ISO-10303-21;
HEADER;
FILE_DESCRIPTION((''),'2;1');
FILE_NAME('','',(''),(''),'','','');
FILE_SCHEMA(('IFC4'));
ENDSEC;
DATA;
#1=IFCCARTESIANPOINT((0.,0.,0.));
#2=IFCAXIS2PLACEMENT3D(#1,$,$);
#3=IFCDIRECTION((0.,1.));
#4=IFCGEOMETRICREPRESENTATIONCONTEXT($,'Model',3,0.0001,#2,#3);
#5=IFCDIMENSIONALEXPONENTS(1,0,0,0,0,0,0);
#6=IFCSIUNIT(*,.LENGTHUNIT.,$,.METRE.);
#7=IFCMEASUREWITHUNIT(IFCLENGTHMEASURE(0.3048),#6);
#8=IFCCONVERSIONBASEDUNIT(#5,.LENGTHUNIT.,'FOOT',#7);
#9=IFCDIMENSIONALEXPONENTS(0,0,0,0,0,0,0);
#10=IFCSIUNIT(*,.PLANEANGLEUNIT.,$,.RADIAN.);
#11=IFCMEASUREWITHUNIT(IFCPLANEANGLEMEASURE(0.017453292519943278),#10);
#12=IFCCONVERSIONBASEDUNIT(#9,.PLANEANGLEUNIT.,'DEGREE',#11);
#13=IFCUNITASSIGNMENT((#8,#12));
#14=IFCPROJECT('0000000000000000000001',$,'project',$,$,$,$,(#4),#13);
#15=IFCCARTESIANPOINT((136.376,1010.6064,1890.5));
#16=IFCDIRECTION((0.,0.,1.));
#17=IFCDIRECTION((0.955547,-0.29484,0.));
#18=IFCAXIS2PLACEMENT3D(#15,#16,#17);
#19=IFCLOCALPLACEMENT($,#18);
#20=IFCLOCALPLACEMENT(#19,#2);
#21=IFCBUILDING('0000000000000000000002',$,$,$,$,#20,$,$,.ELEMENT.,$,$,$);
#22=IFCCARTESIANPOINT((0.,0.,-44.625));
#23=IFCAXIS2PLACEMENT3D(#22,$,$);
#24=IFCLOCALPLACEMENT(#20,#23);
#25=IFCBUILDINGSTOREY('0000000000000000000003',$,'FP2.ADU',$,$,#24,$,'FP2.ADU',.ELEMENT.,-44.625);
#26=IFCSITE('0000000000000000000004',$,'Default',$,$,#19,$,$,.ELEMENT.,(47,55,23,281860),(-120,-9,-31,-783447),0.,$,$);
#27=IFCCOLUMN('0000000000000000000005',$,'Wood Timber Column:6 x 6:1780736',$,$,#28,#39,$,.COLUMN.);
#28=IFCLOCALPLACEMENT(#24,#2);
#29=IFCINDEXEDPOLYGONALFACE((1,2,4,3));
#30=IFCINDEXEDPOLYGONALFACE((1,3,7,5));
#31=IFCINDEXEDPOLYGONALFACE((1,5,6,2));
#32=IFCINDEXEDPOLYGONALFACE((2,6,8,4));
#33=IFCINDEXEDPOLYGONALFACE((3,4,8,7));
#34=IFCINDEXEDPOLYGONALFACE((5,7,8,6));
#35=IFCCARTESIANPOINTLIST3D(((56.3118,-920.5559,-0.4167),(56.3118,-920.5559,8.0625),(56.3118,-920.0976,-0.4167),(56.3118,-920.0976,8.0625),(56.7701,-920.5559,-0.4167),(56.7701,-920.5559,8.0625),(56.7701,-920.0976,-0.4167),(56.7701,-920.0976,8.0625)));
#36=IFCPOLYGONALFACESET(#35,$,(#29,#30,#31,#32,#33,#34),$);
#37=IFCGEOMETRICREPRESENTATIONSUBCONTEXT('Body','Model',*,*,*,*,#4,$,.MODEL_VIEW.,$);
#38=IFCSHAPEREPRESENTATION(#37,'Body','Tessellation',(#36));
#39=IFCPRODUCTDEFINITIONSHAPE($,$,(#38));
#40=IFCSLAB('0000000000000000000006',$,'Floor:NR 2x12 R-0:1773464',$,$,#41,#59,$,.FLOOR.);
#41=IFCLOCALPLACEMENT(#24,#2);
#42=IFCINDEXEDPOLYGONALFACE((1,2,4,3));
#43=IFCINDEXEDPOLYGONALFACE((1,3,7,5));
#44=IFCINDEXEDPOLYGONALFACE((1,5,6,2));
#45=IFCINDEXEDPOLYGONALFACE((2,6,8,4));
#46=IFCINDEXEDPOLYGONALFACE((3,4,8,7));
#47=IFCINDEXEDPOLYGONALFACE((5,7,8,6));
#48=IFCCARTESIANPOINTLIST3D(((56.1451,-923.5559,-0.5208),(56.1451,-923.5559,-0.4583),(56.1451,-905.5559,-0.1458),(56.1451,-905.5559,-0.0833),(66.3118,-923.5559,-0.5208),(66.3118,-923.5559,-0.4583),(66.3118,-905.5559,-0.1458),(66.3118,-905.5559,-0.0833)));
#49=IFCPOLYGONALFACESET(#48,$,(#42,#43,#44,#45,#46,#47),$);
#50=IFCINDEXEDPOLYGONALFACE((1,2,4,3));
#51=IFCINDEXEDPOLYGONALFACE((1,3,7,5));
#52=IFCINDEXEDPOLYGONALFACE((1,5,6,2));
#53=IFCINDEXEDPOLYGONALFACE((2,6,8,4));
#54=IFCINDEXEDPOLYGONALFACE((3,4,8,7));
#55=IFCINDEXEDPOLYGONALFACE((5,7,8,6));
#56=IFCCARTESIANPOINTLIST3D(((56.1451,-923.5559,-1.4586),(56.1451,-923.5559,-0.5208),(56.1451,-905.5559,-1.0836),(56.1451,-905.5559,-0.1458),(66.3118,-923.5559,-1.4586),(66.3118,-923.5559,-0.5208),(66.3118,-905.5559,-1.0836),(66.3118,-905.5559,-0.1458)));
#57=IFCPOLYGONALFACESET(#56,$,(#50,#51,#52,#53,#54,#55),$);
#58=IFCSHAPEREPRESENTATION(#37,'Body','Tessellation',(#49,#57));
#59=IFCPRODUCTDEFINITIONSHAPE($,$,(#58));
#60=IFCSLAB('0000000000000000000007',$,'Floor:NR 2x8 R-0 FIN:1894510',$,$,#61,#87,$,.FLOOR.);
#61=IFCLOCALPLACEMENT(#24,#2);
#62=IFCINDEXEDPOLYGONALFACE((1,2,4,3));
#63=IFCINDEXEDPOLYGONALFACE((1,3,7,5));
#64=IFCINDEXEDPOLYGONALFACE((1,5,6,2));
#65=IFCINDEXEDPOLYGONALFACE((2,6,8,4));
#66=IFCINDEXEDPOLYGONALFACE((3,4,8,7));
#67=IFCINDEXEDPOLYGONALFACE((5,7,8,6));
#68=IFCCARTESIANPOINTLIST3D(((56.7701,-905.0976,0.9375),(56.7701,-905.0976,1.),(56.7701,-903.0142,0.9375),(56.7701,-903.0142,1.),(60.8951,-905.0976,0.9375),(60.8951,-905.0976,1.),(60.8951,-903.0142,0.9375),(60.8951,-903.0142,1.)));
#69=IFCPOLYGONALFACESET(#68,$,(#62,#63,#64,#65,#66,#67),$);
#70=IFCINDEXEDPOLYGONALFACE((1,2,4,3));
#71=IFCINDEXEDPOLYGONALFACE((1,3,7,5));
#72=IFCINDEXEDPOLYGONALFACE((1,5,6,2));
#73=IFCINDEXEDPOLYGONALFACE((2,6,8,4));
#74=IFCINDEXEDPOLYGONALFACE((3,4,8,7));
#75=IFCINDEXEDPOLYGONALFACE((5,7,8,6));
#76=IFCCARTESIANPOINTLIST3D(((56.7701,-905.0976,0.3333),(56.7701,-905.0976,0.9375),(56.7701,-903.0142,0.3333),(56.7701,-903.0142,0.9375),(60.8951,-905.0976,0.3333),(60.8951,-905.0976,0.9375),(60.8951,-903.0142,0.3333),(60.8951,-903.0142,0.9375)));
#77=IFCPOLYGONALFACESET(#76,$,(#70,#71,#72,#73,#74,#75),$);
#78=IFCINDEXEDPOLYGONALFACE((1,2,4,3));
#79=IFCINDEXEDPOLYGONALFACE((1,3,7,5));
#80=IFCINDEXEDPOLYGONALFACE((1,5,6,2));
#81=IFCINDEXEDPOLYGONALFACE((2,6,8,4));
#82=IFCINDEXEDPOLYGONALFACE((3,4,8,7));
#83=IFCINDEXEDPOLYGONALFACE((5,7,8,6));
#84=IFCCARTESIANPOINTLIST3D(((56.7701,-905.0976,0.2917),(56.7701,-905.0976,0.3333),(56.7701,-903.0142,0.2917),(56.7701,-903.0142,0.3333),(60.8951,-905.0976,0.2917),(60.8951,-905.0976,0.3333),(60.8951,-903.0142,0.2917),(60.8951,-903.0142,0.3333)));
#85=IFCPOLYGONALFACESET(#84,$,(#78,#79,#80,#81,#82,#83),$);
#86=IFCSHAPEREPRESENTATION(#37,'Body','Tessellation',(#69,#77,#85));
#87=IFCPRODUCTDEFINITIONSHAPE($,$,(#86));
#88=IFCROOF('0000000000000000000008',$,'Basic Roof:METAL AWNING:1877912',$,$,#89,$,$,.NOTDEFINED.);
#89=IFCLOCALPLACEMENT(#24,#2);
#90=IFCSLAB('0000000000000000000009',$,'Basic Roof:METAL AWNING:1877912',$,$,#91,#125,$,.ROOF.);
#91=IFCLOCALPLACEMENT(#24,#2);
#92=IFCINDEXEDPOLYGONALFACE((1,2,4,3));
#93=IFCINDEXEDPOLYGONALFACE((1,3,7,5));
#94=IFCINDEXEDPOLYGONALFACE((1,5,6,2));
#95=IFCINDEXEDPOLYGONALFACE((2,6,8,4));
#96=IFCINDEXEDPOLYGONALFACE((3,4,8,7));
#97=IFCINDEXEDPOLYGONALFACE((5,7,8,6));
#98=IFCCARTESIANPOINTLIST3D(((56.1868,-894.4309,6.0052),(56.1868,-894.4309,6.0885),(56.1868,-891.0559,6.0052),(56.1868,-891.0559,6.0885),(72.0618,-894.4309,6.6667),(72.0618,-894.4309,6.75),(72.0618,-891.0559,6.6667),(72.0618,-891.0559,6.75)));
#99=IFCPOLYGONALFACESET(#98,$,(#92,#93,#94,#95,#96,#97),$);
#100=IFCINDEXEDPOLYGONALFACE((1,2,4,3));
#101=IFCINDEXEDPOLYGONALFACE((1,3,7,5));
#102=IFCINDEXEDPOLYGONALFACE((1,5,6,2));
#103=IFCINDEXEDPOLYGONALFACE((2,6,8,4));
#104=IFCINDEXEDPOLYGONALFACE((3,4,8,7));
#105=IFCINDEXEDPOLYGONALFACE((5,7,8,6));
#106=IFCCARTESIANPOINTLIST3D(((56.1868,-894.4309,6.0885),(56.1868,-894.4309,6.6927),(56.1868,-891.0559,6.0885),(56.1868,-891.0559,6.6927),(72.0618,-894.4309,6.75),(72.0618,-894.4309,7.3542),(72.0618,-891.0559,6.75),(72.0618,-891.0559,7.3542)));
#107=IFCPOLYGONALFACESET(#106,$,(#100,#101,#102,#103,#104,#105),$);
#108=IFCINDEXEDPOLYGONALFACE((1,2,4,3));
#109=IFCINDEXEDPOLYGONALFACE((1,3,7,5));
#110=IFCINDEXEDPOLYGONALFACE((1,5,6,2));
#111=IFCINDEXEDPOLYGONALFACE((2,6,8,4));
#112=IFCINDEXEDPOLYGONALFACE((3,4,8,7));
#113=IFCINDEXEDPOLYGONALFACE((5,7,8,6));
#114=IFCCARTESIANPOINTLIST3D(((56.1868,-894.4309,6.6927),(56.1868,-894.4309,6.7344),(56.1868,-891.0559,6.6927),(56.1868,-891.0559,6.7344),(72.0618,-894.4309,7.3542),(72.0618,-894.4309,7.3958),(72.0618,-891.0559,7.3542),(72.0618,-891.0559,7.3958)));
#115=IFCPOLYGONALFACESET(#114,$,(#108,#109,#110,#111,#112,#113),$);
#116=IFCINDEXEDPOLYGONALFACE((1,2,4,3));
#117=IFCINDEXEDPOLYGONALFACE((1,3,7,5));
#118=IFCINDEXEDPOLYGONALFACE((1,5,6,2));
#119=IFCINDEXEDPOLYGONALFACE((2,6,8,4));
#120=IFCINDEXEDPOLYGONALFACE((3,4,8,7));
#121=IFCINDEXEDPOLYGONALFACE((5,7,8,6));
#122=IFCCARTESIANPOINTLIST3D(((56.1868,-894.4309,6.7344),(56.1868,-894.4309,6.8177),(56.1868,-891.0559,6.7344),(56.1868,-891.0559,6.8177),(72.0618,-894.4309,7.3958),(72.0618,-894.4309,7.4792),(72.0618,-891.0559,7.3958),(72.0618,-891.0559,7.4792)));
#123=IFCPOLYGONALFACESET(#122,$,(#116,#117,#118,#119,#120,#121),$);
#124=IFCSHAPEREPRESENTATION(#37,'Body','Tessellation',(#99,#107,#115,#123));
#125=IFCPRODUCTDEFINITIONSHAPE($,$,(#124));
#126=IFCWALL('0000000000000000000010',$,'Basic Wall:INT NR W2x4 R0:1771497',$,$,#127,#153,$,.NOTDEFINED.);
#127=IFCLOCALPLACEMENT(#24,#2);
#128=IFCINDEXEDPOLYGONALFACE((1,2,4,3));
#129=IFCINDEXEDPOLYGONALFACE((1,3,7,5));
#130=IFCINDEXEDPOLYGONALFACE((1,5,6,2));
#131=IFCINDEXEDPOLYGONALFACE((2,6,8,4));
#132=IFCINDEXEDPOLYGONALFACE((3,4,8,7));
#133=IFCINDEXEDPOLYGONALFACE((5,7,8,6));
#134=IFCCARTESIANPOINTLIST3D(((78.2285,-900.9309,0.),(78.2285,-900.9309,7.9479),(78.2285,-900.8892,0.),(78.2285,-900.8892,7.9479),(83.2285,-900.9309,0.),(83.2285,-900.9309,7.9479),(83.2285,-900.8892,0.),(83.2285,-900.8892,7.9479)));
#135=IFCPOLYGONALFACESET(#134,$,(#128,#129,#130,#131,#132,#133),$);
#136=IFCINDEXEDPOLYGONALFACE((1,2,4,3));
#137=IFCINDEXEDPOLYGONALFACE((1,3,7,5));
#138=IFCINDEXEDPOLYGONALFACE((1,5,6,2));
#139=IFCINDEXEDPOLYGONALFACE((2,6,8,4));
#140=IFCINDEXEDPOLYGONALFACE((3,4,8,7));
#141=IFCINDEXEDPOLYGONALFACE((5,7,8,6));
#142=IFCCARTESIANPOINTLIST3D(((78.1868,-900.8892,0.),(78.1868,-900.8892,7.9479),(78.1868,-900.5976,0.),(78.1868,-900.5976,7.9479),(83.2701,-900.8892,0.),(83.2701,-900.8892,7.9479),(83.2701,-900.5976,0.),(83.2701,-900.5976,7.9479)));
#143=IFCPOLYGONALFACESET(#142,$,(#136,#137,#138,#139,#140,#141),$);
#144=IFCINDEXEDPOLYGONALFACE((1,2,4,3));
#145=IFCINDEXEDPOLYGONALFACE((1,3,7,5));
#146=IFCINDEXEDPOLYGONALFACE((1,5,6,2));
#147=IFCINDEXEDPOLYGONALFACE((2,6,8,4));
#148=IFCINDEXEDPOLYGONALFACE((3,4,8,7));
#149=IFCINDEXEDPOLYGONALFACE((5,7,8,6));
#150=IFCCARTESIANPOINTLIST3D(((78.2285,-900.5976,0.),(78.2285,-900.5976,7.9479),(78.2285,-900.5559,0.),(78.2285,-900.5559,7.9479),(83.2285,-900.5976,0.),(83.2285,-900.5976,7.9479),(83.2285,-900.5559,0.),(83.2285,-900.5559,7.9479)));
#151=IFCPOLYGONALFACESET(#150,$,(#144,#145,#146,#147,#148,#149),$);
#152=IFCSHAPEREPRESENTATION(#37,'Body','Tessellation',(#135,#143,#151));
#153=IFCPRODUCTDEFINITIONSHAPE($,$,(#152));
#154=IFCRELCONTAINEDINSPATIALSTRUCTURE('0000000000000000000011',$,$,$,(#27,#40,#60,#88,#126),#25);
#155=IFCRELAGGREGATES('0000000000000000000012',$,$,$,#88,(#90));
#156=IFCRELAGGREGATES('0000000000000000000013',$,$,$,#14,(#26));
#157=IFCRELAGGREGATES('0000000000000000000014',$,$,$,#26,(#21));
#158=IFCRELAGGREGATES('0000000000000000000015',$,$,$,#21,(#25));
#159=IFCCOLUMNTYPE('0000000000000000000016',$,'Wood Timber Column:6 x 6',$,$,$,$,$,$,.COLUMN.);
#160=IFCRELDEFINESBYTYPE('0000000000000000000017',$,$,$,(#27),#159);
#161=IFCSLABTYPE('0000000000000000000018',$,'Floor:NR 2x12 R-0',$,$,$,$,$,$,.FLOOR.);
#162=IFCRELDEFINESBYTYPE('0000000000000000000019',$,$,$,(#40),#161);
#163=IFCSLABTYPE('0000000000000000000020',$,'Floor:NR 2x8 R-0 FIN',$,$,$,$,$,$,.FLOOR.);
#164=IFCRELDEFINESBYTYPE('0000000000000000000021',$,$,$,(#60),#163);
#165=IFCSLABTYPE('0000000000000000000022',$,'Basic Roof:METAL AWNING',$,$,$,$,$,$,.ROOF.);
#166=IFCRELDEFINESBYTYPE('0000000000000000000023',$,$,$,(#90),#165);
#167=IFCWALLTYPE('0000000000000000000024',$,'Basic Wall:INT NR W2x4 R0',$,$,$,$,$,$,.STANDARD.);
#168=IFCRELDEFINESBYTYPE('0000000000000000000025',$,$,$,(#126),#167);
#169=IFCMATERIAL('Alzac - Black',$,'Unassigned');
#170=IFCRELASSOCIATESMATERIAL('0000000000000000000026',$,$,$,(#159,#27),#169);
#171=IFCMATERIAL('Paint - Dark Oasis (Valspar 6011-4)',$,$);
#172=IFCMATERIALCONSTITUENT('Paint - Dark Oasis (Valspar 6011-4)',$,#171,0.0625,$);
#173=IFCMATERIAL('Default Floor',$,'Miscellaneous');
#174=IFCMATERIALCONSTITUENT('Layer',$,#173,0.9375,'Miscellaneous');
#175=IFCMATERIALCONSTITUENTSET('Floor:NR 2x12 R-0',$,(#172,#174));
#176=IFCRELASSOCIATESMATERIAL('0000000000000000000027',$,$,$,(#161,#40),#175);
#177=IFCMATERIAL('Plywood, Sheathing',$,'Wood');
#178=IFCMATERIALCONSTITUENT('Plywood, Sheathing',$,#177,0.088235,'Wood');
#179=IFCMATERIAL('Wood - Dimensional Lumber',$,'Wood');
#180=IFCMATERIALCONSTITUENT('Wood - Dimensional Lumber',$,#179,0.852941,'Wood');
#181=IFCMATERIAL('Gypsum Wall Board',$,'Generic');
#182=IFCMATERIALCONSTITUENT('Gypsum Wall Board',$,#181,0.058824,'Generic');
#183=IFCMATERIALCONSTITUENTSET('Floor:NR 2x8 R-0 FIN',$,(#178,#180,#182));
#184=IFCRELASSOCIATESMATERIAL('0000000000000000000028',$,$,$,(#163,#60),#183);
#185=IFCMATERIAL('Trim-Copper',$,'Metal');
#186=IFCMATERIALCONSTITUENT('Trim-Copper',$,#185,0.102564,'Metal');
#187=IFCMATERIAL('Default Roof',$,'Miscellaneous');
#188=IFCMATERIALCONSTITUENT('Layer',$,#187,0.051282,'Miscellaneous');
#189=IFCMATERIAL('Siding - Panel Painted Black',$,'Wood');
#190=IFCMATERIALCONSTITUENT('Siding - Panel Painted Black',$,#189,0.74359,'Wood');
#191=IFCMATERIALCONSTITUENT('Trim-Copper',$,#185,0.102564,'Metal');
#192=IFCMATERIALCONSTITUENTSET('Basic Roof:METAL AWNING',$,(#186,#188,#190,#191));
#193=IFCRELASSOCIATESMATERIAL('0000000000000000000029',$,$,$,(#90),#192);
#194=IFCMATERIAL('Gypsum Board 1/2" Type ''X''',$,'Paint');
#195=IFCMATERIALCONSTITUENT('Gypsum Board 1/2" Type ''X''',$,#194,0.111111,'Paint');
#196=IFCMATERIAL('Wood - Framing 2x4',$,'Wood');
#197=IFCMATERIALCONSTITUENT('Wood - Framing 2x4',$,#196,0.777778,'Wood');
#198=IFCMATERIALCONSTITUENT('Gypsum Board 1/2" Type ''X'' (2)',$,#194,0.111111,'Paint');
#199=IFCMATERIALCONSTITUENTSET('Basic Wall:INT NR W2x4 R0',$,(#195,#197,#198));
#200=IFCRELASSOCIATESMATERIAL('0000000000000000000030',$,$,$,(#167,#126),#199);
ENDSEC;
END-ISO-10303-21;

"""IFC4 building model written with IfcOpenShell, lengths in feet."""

from ifc_helpers import new_model, entity, si_unit, converted_unit, direction, frame, origin, place, context, subcontext, project, spatial, indexed_curve, outline, extrude, source, transform, mapped, material, constituent, constituent_set, type_object, type_shapes, element, aggregate, save


model = new_model("IFC4")

# Units and contexts
model_context = context("Model", 3, precision=0.0001, world=origin(), true_north=direction((0.0, 1.0)))
body_context = subcontext(model_context, "Body", "Model", "MODEL_VIEW")
ifc_project = project(units=[converted_unit("LENGTHUNIT", "FOOT", entity("IfcLengthMeasure", 0.3048), si_unit("LENGTHUNIT", "METRE"), dimensions=[1, 0, 0, 0, 0, 0, 0]), converted_unit("PLANEANGLEUNIT", "DEGREE", entity("IfcPlaneAngleMeasure", 0.017453292519943278), si_unit("PLANEANGLEUNIT", "RADIAN"), dimensions=[0, 0, 0, 0, 0, 0, 0])], contexts=[model_context])

# Site, building, storey
site_placement = place(None, frame((136.376, 1010.6064, 1890.5), z_axis=(0.0, 0.0, 1.0), x_axis=(0.955547, -0.29484, 0.0)))
site = spatial("IfcSite", under=ifc_project, at=site_placement, Name="Default", CompositionType="ELEMENT", RefLatitude=(47, 55, 23, 281860), RefLongitude=(-120, -9, -31, -783447), RefElevation=0.0)
building_placement = place(site_placement, origin())
building = spatial("IfcBuilding", under=site, at=building_placement, CompositionType="ELEMENT")
storey_placement = place(building_placement, frame((0.0, 0.0, -44.625)))
storey = spatial("IfcBuildingStorey", under=building, at=storey_placement, Name="FP2.ADU", LongName="FP2.ADU", CompositionType="ELEMENT", Elevation=-44.625)

# Column
ifc_material_1 = material(Name="Alzac - Black", Category="Unassigned")
column_type = type_object("IfcColumnType", Name="Wood Timber Column:6 x 6", PredefinedType="COLUMN", material=ifc_material_1)
shared_shape_1 = source(origin(), body_context, "Body", "SweptSolid", [
    extrude(outline(indexed_curve([(-0.2292, -0.2292), (0.2292, -0.2292), (0.2292, 0.2292), (-0.2292, 0.2292), (-0.2292, -0.2292)], self_intersect=False)), frame((56.541, -920.3267, -45.0417), z_axis=(0.0, 0.0, 1.0), x_axis=(0.0, 1.0, 0.0)), (0.0, 0.0, 1.0), 8.4792),
])
type_shapes(column_type, [shared_shape_1])
column_placement = place(storey_placement, frame((0.0, 0.0, 44.625)))
element("IfcColumn", 1, at=column_placement, inside=storey, type_object=column_type, material=ifc_material_1, Name="Wood Timber Column:6 x 6:1780736", PredefinedType="COLUMN", context=body_context, shape_type="MappedRepresentation", body=[
    mapped(shared_shape_1, transform((0.0, 0.0, 0.0), scale=1.0)),
])

# Slabs
ifc_material_2 = material(Name="Paint - Dark Oasis (Valspar 6011-4)")
ifc_constituent_1 = constituent(ifc_material_2, Name="Paint - Dark Oasis (Valspar 6011-4)", fraction=0.0625)
ifc_material_3 = material(Name="Default Floor", Category="Miscellaneous")
ifc_constituent_2 = constituent(ifc_material_3, Name="Layer", Category="Miscellaneous", fraction=0.9375)
ifc_constituent_set_1 = constituent_set(constituents=[ifc_constituent_1, ifc_constituent_2], Name="Floor:NR 2x12 R-0")
slab_type_1 = type_object("IfcSlabType", Name="Floor:NR 2x12 R-0", PredefinedType="FLOOR", material=ifc_constituent_set_1)
slab_1_placement = place(storey_placement, origin())
element("IfcSlab", 2, at=slab_1_placement, inside=storey, type_object=slab_type_1, material=ifc_constituent_set_1, Name="Floor:NR 2x12 R-0:1773464", PredefinedType="FLOOR", context=body_context, shape_type="SweptSolid", body=[
    extrude(outline(indexed_curve([(0.1562, -9.0), (0.2188, -9.0), (-0.1562, 9.0), (-0.2188, 9.0), (0.1562, -9.0)], self_intersect=False)), frame((56.1451, -914.5559, -0.3021), z_axis=(1.0, 0.0, 0.0), x_axis=(0.0, 0.0, -1.0)), (0.0, 0.0, 1.0), 10.1667),
    extrude(outline(indexed_curve([(-0.2814, -9.0), (0.6564, -9.0), (0.2814, 9.0), (-0.6564, 9.0), (-0.2814, -9.0)], self_intersect=False)), frame((56.1451, -914.5559, -0.8022), z_axis=(1.0, 0.0, 0.0), x_axis=(0.0, 0.0, 1.0)), (0.0, 0.0, 1.0), 10.1667),
])
ifc_material_4 = material(Name="Siding - Panel Painted Black", Category="Wood")
ifc_material_5 = material(Name="Gypsum Wall Board", Category="Generic")
ifc_material_6 = material(Name="Plywood, Sheathing", Category="Wood")
ifc_constituent_3 = constituent(ifc_material_6, Name="Plywood, Sheathing", Category="Wood", fraction=0.088235)
ifc_material_7 = material(Name="Wood - Dimensional Lumber", Category="Wood")
ifc_constituent_4 = constituent(ifc_material_7, Name="Wood - Dimensional Lumber", Category="Wood", fraction=0.852941)
ifc_constituent_5 = constituent(ifc_material_5, Name="Gypsum Wall Board", Category="Generic", fraction=0.058824)
ifc_constituent_set_2 = constituent_set(constituents=[ifc_constituent_3, ifc_constituent_4, ifc_constituent_5], Name="Floor:NR 2x8 R-0 FIN")
slab_type_2 = type_object("IfcSlabType", Name="Floor:NR 2x8 R-0 FIN", PredefinedType="FLOOR", material=ifc_constituent_set_2)
slab_2_placement = place(storey_placement, origin())
element("IfcSlab", 3, at=slab_2_placement, inside=storey, type_object=slab_type_2, material=ifc_constituent_set_2, Name="Floor:NR 2x8 R-0 FIN:1894510", PredefinedType="FLOOR", context=body_context, shape_type="SweptSolid", body=[
    extrude(outline(indexed_curve([(-2.0625, -1.0417), (2.0625, -1.0417), (2.0625, 1.0417), (-2.0625, 1.0417), (-2.0625, -1.0417)], self_intersect=False)), frame((58.8326, -904.0559, 0.9375), z_axis=(0.0, 0.0, 1.0), x_axis=(-1.0, 0.0, 0.0)), (0.0, 0.0, 1.0), 0.0625),
    extrude(outline(indexed_curve([(-2.0625, -1.0417), (2.0625, -1.0417), (2.0625, 1.0417), (-2.0625, 1.0417), (-2.0625, -1.0417)], self_intersect=False)), frame((58.8326, -904.0559, 0.3333), z_axis=(0.0, 0.0, 1.0), x_axis=(-1.0, 0.0, 0.0)), (0.0, 0.0, 1.0), 0.6042),
    extrude(outline(indexed_curve([(-2.0625, -1.0417), (2.0625, -1.0417), (2.0625, 1.0417), (-2.0625, 1.0417), (-2.0625, -1.0417)], self_intersect=False)), frame((58.8326, -904.0559, 0.2917), z_axis=(0.0, 0.0, 1.0), x_axis=(-1.0, 0.0, 0.0)), (0.0, 0.0, 1.0), 0.0417),
])

# Roof, slab
roof_placement = place(storey_placement, frame((56.1868, -894.4309, 6.0052)))
roof = element("IfcRoof", 4, at=roof_placement, inside=storey, Name="Basic Roof:METAL AWNING:1877912", PredefinedType="NOTDEFINED")
ifc_material_8 = material(Name="Trim-Copper", Category="Metal")
ifc_constituent_6 = constituent(ifc_material_8, Name="Trim-Copper", Category="Metal", fraction=0.102564)
ifc_material_9 = material(Name="Default Roof", Category="Miscellaneous")
ifc_constituent_7 = constituent(ifc_material_9, Name="Layer", Category="Miscellaneous", fraction=0.051282)
ifc_constituent_8 = constituent(ifc_material_4, Name="Siding - Panel Painted Black", Category="Wood", fraction=0.74359)
ifc_constituent_9 = constituent(ifc_material_8, Name="Trim-Copper", Category="Metal", fraction=0.102564)
ifc_constituent_set_3 = constituent_set(constituents=[ifc_constituent_6, ifc_constituent_7, ifc_constituent_8, ifc_constituent_9], Name="Basic Roof:METAL AWNING")
slab_type_3 = type_object("IfcSlabType", Name="Basic Roof:METAL AWNING", PredefinedType="ROOF")
slab_3_placement = place(roof_placement, origin())
slab_3 = element("IfcSlab", 5, at=slab_3_placement, type_object=slab_type_3, material=ifc_constituent_set_3, Name="Basic Roof:METAL AWNING:1877912", PredefinedType="ROOF", context=body_context, shape_type="SweptSolid", body=[
    extrude(outline(indexed_curve([(-7.9444, 1.6875), (-7.9444, -1.6875), (7.9444, -1.6875), (7.9444, 1.6875), (-7.9444, 1.6875)], self_intersect=False)), frame((7.9375, 1.6875, 0.3307), z_axis=(-0.041631, 0.0, 0.999133), x_axis=(0.999133, 0.0, 0.041631)), (0.041631, 0.0, 0.999133), 0.0833),
    extrude(outline(indexed_curve([(-7.9444, 1.6875), (-7.9444, -1.6875), (7.9444, -1.6875), (7.9444, 1.6875), (-7.9444, 1.6875)], self_intersect=False)), frame((7.9375, 1.6875, 0.4141), z_axis=(-0.041631, 0.0, 0.999133), x_axis=(0.999133, 0.0, 0.041631)), (0.041631, 0.0, 0.999133), 0.6042),
    extrude(outline(indexed_curve([(-7.9444, 1.6875), (-7.9444, -1.6875), (7.9444, -1.6875), (7.9444, 1.6875), (-7.9444, 1.6875)], self_intersect=False)), frame((7.9375, 1.6875, 1.0182), z_axis=(-0.041631, 0.0, 0.999133), x_axis=(0.999133, 0.0, 0.041631)), (0.041631, 0.0, 0.999133), 0.0417),
    extrude(outline(indexed_curve([(-7.9444, 1.6875), (-7.9444, -1.6875), (7.9444, -1.6875), (7.9444, 1.6875), (-7.9444, 1.6875)], self_intersect=False)), frame((7.9375, 1.6875, 1.0599), z_axis=(-0.041631, 0.0, 0.999133), x_axis=(0.999133, 0.0, 0.041631)), (0.041631, 0.0, 0.999133), 0.0833),
])
aggregate(roof, [slab_3])

# Shared definitions
ifc_material_10 = material(Name="Gypsum Board 1/2\" Type 'X'", Category="Paint")

# Shared definitions
ifc_constituent_10 = constituent(ifc_material_10, Name="Gypsum Board 1/2\" Type 'X'", Category="Paint", fraction=0.111111)
ifc_material_11 = material(Name="Wood - Framing 2x4", Category="Wood")
ifc_constituent_11 = constituent(ifc_material_11, Name="Wood - Framing 2x4", Category="Wood", fraction=0.777778)
ifc_constituent_12 = constituent(ifc_material_10, Name="Gypsum Board 1/2\" Type 'X' (2)", Category="Paint", fraction=0.111111)
ifc_constituent_set_4 = constituent_set(constituents=[ifc_constituent_10, ifc_constituent_11, ifc_constituent_12], Name="Basic Wall:INT NR W2x4 R0")
wall_type_1 = type_object("IfcWallType", Name="Basic Wall:INT NR W2x4 R0", PredefinedType="STANDARD", material=ifc_constituent_set_4)

# Wall
wall_1_placement = place(storey_placement, frame((78.2285, -900.7434, 0.0)))
element("IfcWall", 6, at=wall_1_placement, inside=storey, type_object=wall_type_1, material=ifc_constituent_set_4, Name="Basic Wall:INT NR W2x4 R0:1771497", PredefinedType="NOTDEFINED", context=body_context, shape_type="SweptSolid", body=[
    extrude(outline(indexed_curve([(-0.0208, -2.5), (0.0208, -2.5), (0.0208, 2.5), (-0.0208, 2.5), (-0.0208, -2.5)], self_intersect=False)), frame((2.5, -0.1667, 0.0), z_axis=(0.0, 0.0, 1.0), x_axis=(0.0, 1.0, 0.0)), (0.0, 0.0, 1.0), 7.9479),
    extrude(outline(indexed_curve([(-2.5417, -0.1458), (2.5417, -0.1458), (2.5417, 0.1458), (-2.5417, 0.1458), (-2.5417, -0.1458)], self_intersect=False)), frame((2.5, 0.0, 0.0)), (0.0, 0.0, 1.0), 7.9479),
    extrude(outline(indexed_curve([(-0.0208, -2.5), (0.0208, -2.5), (0.0208, 2.5), (-0.0208, 2.5), (-0.0208, -2.5)], self_intersect=False)), frame((2.5, 0.1667, 0.0), z_axis=(0.0, 0.0, 1.0), x_axis=(0.0, -1.0, 0.0)), (0.0, 0.0, 1.0), 7.9479),
])

save(model, "model.ifc")
